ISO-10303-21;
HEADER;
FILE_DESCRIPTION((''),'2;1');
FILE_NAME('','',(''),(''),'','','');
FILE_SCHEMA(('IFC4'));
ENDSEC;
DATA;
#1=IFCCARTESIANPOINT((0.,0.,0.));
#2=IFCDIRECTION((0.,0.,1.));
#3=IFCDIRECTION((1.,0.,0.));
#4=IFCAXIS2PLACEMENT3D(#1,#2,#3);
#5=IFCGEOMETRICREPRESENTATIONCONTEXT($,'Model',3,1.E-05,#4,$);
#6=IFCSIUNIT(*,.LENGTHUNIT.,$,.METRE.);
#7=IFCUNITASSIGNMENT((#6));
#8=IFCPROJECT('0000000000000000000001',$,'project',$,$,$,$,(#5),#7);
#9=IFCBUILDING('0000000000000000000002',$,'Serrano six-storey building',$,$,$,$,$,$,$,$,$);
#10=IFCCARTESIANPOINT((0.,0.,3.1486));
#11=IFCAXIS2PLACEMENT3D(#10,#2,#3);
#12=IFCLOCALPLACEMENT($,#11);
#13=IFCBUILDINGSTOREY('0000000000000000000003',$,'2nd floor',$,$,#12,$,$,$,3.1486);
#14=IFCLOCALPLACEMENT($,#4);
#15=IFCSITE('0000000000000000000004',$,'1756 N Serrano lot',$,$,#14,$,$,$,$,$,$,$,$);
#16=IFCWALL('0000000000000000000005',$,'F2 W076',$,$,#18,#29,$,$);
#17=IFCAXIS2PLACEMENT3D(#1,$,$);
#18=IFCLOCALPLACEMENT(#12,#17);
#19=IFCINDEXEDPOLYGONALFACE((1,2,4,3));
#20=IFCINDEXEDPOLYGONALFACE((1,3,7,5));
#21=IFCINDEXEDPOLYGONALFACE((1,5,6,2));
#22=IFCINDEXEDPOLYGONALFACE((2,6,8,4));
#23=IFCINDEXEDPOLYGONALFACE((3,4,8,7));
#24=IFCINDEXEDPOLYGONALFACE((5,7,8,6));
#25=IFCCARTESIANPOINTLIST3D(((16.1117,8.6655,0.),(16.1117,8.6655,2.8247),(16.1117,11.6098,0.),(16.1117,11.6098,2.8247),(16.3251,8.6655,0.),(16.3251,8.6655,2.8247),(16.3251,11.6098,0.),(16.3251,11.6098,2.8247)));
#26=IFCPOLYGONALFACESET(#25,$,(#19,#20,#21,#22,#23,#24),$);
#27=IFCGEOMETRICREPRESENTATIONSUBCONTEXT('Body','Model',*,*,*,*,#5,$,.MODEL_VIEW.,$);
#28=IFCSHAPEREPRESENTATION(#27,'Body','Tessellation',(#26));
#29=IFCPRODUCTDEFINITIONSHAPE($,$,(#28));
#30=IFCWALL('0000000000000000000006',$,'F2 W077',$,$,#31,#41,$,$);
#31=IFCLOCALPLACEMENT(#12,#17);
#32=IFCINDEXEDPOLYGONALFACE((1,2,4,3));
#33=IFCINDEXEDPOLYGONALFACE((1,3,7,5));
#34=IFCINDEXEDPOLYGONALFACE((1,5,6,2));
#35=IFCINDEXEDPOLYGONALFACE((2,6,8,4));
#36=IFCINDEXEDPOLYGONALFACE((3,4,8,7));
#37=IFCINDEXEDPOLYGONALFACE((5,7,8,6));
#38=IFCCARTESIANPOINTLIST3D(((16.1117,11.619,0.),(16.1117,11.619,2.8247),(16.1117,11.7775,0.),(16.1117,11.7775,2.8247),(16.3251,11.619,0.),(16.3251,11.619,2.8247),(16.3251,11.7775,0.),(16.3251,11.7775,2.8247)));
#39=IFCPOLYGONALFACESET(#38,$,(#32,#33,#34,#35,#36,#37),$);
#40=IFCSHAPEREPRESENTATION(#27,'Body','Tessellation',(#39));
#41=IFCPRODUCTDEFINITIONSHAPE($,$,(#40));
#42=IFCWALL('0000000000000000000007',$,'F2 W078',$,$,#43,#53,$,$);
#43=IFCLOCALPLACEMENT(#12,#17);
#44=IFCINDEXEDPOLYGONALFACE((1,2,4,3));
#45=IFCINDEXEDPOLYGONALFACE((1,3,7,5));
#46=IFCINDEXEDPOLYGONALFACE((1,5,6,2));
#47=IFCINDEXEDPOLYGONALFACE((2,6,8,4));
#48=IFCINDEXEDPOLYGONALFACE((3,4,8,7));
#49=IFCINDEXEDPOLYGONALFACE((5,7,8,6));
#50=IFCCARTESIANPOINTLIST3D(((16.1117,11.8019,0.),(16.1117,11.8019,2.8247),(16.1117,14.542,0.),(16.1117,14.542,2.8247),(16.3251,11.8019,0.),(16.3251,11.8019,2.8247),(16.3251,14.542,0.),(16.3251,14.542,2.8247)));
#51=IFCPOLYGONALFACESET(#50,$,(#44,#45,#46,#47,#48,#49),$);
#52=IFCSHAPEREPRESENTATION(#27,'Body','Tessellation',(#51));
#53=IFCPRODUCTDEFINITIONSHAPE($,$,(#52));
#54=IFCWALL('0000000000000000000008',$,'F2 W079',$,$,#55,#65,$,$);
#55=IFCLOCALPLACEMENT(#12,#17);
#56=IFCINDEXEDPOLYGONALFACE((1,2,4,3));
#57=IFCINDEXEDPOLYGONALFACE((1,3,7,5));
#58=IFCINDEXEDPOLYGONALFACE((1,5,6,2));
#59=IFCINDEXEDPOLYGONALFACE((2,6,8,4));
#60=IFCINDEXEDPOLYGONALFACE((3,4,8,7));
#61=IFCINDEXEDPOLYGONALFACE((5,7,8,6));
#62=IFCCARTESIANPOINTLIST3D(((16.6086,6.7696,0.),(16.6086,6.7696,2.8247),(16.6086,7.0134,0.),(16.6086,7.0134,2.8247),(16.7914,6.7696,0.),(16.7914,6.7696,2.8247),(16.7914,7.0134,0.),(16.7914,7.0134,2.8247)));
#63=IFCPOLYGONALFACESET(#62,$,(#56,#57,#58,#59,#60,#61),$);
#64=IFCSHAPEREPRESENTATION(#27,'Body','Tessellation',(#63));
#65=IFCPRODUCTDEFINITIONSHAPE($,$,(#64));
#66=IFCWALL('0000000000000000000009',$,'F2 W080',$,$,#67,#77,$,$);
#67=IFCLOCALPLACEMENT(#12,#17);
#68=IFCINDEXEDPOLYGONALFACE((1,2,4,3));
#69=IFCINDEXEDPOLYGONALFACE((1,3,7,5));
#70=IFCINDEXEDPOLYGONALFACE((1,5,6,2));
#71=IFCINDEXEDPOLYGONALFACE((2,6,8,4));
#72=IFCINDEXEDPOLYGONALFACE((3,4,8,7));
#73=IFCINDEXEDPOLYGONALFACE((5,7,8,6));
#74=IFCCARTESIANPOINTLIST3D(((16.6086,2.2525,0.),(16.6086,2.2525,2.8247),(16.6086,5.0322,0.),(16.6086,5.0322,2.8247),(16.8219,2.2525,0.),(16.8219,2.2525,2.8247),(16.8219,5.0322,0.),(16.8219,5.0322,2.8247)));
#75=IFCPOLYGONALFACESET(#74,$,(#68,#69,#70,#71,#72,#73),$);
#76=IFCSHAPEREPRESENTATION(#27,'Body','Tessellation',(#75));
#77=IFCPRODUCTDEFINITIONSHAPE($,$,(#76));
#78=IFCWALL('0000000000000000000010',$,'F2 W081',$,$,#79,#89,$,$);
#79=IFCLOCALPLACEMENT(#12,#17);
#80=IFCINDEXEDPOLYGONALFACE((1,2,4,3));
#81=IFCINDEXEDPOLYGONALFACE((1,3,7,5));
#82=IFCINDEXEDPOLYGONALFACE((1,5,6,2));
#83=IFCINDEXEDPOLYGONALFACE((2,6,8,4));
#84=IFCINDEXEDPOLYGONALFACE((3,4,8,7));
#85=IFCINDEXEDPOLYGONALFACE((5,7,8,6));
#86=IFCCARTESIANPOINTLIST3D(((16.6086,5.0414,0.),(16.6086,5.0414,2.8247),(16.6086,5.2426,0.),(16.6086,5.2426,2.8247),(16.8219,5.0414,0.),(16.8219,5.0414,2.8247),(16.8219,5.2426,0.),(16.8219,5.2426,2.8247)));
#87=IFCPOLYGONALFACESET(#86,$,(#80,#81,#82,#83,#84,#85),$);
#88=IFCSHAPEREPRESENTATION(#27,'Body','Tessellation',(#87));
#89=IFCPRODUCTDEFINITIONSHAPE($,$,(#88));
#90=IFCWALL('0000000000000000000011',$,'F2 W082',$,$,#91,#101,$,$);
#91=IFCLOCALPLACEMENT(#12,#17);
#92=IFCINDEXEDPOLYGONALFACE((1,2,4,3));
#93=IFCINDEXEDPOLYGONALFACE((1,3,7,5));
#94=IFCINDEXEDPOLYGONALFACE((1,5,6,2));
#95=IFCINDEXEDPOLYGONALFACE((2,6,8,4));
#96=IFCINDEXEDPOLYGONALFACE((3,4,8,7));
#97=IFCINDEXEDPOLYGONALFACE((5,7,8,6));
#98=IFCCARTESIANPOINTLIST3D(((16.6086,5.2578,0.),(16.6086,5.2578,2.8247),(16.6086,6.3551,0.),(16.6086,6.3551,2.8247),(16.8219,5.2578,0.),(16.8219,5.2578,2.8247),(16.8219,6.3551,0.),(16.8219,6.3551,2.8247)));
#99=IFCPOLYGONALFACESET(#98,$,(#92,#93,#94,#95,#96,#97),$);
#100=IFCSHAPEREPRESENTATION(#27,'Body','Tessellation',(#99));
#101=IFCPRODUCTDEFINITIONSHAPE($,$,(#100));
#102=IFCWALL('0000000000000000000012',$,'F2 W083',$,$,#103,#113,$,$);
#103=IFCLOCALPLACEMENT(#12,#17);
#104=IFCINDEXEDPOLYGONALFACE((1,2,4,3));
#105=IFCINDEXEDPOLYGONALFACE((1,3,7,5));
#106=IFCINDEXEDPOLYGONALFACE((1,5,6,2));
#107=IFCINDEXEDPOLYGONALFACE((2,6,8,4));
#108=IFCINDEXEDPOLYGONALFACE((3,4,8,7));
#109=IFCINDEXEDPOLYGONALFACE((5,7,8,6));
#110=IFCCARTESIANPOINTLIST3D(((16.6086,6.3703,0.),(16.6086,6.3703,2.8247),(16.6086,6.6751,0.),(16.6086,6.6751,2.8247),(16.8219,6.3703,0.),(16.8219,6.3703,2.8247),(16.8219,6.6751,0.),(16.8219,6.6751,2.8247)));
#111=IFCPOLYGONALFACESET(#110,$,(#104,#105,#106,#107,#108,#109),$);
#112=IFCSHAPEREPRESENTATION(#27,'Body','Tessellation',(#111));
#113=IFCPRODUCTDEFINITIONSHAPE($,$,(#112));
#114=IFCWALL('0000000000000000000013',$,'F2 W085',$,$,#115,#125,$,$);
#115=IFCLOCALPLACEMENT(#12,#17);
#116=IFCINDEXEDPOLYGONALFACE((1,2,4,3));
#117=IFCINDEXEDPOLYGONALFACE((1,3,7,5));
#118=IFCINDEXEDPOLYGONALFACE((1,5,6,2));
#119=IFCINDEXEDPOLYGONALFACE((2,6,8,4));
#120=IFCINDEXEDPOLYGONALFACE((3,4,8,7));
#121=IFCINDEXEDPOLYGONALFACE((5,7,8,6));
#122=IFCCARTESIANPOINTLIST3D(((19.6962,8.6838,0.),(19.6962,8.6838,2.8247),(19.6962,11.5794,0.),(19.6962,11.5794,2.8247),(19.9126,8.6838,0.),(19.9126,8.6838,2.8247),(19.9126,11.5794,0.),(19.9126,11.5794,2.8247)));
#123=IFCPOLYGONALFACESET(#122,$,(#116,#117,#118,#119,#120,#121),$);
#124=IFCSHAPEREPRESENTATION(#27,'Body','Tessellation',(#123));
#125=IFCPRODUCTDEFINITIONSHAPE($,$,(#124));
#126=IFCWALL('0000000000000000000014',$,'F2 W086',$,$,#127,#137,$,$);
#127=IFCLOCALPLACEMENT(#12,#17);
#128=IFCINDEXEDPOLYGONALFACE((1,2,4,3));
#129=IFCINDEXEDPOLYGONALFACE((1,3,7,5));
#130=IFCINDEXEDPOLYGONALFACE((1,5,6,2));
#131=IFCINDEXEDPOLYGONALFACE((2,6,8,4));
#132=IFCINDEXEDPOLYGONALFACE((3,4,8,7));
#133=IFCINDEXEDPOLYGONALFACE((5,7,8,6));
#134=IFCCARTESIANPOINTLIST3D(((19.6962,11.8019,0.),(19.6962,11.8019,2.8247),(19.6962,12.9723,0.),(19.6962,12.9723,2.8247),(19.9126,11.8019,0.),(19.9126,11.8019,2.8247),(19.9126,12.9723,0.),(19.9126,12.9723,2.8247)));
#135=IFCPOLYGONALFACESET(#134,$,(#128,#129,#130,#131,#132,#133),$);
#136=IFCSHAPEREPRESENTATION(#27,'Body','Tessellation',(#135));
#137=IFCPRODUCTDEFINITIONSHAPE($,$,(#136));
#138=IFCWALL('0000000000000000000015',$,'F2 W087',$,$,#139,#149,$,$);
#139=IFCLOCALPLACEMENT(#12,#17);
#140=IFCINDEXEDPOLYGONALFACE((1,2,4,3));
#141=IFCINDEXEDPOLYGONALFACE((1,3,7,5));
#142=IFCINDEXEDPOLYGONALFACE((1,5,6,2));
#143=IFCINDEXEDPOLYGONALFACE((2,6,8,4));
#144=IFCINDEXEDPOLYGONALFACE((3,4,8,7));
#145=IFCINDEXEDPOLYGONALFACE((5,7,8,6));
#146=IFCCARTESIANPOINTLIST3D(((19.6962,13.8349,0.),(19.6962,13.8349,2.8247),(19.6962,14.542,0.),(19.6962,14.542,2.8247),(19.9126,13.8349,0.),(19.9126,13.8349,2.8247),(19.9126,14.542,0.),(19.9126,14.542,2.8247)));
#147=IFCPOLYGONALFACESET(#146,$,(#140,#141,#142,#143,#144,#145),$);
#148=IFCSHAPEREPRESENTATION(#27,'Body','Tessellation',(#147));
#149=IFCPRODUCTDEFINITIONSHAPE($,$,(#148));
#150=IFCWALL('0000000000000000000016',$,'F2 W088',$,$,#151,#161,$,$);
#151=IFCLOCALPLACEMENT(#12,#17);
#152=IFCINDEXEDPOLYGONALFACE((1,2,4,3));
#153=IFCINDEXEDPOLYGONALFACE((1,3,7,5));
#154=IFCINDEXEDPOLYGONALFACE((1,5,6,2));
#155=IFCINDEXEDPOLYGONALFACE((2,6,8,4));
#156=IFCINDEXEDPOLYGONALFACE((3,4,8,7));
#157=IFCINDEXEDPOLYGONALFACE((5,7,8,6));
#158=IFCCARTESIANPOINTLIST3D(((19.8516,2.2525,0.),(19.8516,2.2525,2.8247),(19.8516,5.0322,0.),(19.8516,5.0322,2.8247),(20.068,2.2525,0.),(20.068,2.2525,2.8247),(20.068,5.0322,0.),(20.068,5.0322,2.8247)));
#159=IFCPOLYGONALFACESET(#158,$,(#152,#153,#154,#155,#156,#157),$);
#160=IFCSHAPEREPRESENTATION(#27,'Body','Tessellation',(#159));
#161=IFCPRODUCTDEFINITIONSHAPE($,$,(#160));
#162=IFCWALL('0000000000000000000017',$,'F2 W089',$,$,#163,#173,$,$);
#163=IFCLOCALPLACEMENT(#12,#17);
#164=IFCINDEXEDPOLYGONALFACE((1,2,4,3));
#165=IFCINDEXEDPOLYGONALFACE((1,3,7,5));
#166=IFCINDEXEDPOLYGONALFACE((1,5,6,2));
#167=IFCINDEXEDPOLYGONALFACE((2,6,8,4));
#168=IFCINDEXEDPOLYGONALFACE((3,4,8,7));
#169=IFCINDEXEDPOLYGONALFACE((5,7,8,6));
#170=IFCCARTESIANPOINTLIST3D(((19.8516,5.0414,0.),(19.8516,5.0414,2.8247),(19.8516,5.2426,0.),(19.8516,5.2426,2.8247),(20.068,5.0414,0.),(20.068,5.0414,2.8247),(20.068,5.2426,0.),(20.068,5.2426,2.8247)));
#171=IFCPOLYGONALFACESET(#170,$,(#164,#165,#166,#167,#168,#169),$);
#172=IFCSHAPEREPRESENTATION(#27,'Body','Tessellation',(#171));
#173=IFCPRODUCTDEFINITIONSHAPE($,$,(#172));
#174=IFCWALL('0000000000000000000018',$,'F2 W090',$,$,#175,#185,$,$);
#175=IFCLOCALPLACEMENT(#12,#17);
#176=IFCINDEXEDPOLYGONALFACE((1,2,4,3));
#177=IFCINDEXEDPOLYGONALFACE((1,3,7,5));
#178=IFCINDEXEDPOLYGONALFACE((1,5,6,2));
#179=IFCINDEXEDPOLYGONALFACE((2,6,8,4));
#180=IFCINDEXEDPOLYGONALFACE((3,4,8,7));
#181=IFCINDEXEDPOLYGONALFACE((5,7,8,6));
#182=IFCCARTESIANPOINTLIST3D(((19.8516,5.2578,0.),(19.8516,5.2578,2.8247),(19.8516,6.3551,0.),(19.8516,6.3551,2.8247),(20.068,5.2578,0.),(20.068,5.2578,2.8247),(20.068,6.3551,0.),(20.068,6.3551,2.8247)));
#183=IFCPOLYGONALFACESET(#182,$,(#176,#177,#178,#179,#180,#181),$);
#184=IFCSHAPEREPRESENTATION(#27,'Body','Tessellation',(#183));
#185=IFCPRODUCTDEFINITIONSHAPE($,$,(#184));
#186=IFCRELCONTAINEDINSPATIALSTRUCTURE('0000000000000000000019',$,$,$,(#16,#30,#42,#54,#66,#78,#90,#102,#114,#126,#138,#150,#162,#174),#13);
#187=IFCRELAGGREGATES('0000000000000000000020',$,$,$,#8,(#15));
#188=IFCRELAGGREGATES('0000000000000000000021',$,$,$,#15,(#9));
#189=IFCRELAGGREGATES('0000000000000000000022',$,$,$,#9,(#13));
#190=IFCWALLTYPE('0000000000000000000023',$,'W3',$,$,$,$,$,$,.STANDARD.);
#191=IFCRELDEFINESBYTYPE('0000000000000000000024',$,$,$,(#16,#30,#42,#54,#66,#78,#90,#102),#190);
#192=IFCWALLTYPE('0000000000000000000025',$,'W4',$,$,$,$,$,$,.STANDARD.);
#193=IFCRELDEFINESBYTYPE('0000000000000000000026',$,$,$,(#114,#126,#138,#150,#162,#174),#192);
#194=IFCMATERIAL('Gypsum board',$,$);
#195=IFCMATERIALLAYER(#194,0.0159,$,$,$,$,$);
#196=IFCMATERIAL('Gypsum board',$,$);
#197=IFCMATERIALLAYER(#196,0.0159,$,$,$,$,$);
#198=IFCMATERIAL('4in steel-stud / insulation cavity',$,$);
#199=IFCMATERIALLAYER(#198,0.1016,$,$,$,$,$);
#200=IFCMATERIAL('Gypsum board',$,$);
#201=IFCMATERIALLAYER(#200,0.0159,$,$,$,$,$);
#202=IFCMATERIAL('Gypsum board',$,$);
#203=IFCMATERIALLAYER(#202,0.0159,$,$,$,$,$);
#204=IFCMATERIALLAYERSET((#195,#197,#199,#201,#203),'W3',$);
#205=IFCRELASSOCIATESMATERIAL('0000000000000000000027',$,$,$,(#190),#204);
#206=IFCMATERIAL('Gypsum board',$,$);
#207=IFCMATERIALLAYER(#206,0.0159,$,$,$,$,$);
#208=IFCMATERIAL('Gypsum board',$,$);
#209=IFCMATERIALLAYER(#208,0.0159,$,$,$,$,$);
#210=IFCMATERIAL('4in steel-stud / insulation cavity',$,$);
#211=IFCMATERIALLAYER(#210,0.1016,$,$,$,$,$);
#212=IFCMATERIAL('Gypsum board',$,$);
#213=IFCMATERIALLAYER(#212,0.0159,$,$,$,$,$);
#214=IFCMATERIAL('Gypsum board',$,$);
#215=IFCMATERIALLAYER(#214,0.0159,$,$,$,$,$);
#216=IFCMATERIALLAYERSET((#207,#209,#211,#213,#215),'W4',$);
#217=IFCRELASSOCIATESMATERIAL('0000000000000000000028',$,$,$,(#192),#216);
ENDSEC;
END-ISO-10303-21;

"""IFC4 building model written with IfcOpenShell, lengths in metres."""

from ifc_helpers import new_model, si_unit, frame, origin_with_axes, place, context, subcontext, project, spatial, polyline, outline, extrude, material, layer, layer_set, type_object, element, save


model = new_model("IFC4")

# Units and contexts
model_context = context("Model", 3, precision=1e-05, world=origin_with_axes())
body_context = subcontext(model_context, "Body", "Model", "MODEL_VIEW")
ifc_project = project(units=[si_unit("LENGTHUNIT", "METRE")], contexts=[model_context])

# Site, building, storey
site_placement = place(None, origin_with_axes())
site = spatial("IfcSite", under=ifc_project, at=site_placement, Name="1756 N Serrano lot")
building = spatial("IfcBuilding", under=site, Name="Serrano six-storey building")
storey_placement = place(None, frame((0.0, 0.0, 3.1486), z_axis=(0.0, 0.0, 1.0), x_axis=(1.0, 0.0, 0.0)))
storey = spatial("IfcBuildingStorey", under=building, at=storey_placement, Name="2nd floor", Elevation=3.1486)

# Walls
ifc_material_1 = material(Name="Gypsum board")
ifc_layer_1 = layer(ifc_material_1, 0.0159)
ifc_material_2 = material(Name="Gypsum board")
ifc_layer_2 = layer(ifc_material_2, 0.0159)
ifc_material_3 = material(Name="4in steel-stud / insulation cavity")
ifc_layer_3 = layer(ifc_material_3, 0.1016)
ifc_material_4 = material(Name="Gypsum board")
ifc_layer_4 = layer(ifc_material_4, 0.0159)
ifc_material_5 = material(Name="Gypsum board")
ifc_layer_5 = layer(ifc_material_5, 0.0159)
ifc_layer_set_1 = layer_set([ifc_layer_1, ifc_layer_2, ifc_layer_3, ifc_layer_4, ifc_layer_5], Name="W3")
wall_type_1 = type_object("IfcWallType", Name="W3", PredefinedType="STANDARD", material=ifc_layer_set_1)
wall_1_placement = place(storey_placement, frame((0.0, 0.0, -3.1486), z_axis=(0.0, 0.0, 1.0), x_axis=(1.0, 0.0, 0.0)))
element("IfcWall", 1, at=wall_1_placement, inside=storey, type_object=wall_type_1, Name="F2 W076", context=body_context, shape_type="SweptSolid", body=[
    extrude(outline(polyline([(16.1117, 11.6098), (16.3251, 11.6098), (16.3251, 8.6655), (16.1117, 8.6655), (16.1117, 11.6098)])), frame((0.0, 0.0, 3.1486)), (0.0, 0.0, 1.0), 2.8247),
])
wall_2_placement = place(storey_placement, frame((0.0, 0.0, -3.1486), z_axis=(0.0, 0.0, 1.0), x_axis=(1.0, 0.0, 0.0)))
element("IfcWall", 2, at=wall_2_placement, inside=storey, type_object=wall_type_1, Name="F2 W077", context=body_context, shape_type="SweptSolid", body=[
    extrude(outline(polyline([(16.1117, 11.7775), (16.3251, 11.7775), (16.3251, 11.619), (16.1117, 11.619), (16.1117, 11.7775)])), frame((0.0, 0.0, 3.1486)), (0.0, 0.0, 1.0), 2.8247),
])
wall_3_placement = place(storey_placement, frame((0.0, 0.0, -3.1486), z_axis=(0.0, 0.0, 1.0), x_axis=(1.0, 0.0, 0.0)))
element("IfcWall", 3, at=wall_3_placement, inside=storey, type_object=wall_type_1, Name="F2 W078", context=body_context, shape_type="SweptSolid", body=[
    extrude(outline(polyline([(16.1117, 14.542), (16.3251, 14.542), (16.3251, 11.8019), (16.1117, 11.8019), (16.1117, 14.542)])), frame((0.0, 0.0, 3.1486)), (0.0, 0.0, 1.0), 2.8247),
])
wall_4_placement = place(storey_placement, frame((0.0, 0.0, -3.1486), z_axis=(0.0, 0.0, 1.0), x_axis=(1.0, 0.0, 0.0)))
element("IfcWall", 4, at=wall_4_placement, inside=storey, type_object=wall_type_1, Name="F2 W079", context=body_context, shape_type="SweptSolid", body=[
    extrude(outline(polyline([(16.6086, 7.0134), (16.7914, 7.0134), (16.7914, 6.7696), (16.6086, 6.7696), (16.6086, 7.0134)])), frame((0.0, 0.0, 3.1486)), (0.0, 0.0, 1.0), 2.8247),
])
wall_5_placement = place(storey_placement, frame((0.0, 0.0, -3.1486), z_axis=(0.0, 0.0, 1.0), x_axis=(1.0, 0.0, 0.0)))
element("IfcWall", 5, at=wall_5_placement, inside=storey, type_object=wall_type_1, Name="F2 W080", context=body_context, shape_type="SweptSolid", body=[
    extrude(outline(polyline([(16.6086, 5.0322), (16.8219, 5.0322), (16.8219, 2.2525), (16.6086, 2.2525), (16.6086, 5.0322)])), frame((0.0, 0.0, 3.1486)), (0.0, 0.0, 1.0), 2.8247),
])
wall_6_placement = place(storey_placement, frame((0.0, 0.0, -3.1486), z_axis=(0.0, 0.0, 1.0), x_axis=(1.0, 0.0, 0.0)))
element("IfcWall", 6, at=wall_6_placement, inside=storey, type_object=wall_type_1, Name="F2 W081", context=body_context, shape_type="SweptSolid", body=[
    extrude(outline(polyline([(16.6086, 5.2426), (16.8219, 5.2426), (16.8219, 5.0414), (16.6086, 5.0414), (16.6086, 5.2426)])), frame((0.0, 0.0, 3.1486)), (0.0, 0.0, 1.0), 2.8247),
])
wall_7_placement = place(storey_placement, frame((0.0, 0.0, -3.1486), z_axis=(0.0, 0.0, 1.0), x_axis=(1.0, 0.0, 0.0)))
element("IfcWall", 7, at=wall_7_placement, inside=storey, type_object=wall_type_1, Name="F2 W082", context=body_context, shape_type="SweptSolid", body=[
    extrude(outline(polyline([(16.6086, 6.3551), (16.8219, 6.3551), (16.8219, 5.2578), (16.6086, 5.2578), (16.6086, 6.3551)])), frame((0.0, 0.0, 3.1486)), (0.0, 0.0, 1.0), 2.8247),
])
wall_8_placement = place(storey_placement, frame((0.0, 0.0, -3.1486), z_axis=(0.0, 0.0, 1.0), x_axis=(1.0, 0.0, 0.0)))
element("IfcWall", 8, at=wall_8_placement, inside=storey, type_object=wall_type_1, Name="F2 W083", context=body_context, shape_type="SweptSolid", body=[
    extrude(outline(polyline([(16.6086, 6.6751), (16.8219, 6.6751), (16.8219, 6.3703), (16.6086, 6.3703), (16.6086, 6.6751)])), frame((0.0, 0.0, 3.1486)), (0.0, 0.0, 1.0), 2.8247),
])
ifc_material_6 = material(Name="Gypsum board")
ifc_layer_6 = layer(ifc_material_6, 0.0159)
ifc_material_7 = material(Name="Gypsum board")
ifc_layer_7 = layer(ifc_material_7, 0.0159)
ifc_material_8 = material(Name="4in steel-stud / insulation cavity")
ifc_layer_8 = layer(ifc_material_8, 0.1016)
ifc_material_9 = material(Name="Gypsum board")
ifc_layer_9 = layer(ifc_material_9, 0.0159)
ifc_material_10 = material(Name="Gypsum board")
ifc_layer_10 = layer(ifc_material_10, 0.0159)
ifc_layer_set_2 = layer_set([ifc_layer_6, ifc_layer_7, ifc_layer_8, ifc_layer_9, ifc_layer_10], Name="W4")
wall_type_2 = type_object("IfcWallType", Name="W4", PredefinedType="STANDARD", material=ifc_layer_set_2)
wall_9_placement = place(storey_placement, frame((0.0, 0.0, -3.1486), z_axis=(0.0, 0.0, 1.0), x_axis=(1.0, 0.0, 0.0)))
element("IfcWall", 9, at=wall_9_placement, inside=storey, type_object=wall_type_2, Name="F2 W085", context=body_context, shape_type="SweptSolid", body=[
    extrude(outline(polyline([(19.6962, 11.5794), (19.9126, 11.5794), (19.9126, 8.6838), (19.6962, 8.6838), (19.6962, 11.5794)])), frame((0.0, 0.0, 3.1486)), (0.0, 0.0, 1.0), 2.8247),
])
wall_10_placement = place(storey_placement, frame((0.0, 0.0, -3.1486), z_axis=(0.0, 0.0, 1.0), x_axis=(1.0, 0.0, 0.0)))
element("IfcWall", 10, at=wall_10_placement, inside=storey, type_object=wall_type_2, Name="F2 W086", context=body_context, shape_type="SweptSolid", body=[
    extrude(outline(polyline([(19.6962, 12.9723), (19.9126, 12.9723), (19.9126, 11.8019), (19.6962, 11.8019), (19.6962, 12.9723)])), frame((0.0, 0.0, 3.1486)), (0.0, 0.0, 1.0), 2.8247),
])
wall_11_placement = place(storey_placement, frame((0.0, 0.0, -3.1486), z_axis=(0.0, 0.0, 1.0), x_axis=(1.0, 0.0, 0.0)))
element("IfcWall", 11, at=wall_11_placement, inside=storey, type_object=wall_type_2, Name="F2 W087", context=body_context, shape_type="SweptSolid", body=[
    extrude(outline(polyline([(19.6962, 14.542), (19.9126, 14.542), (19.9126, 13.8349), (19.6962, 13.8349), (19.6962, 14.542)])), frame((0.0, 0.0, 3.1486)), (0.0, 0.0, 1.0), 2.8247),
])
wall_12_placement = place(storey_placement, frame((0.0, 0.0, -3.1486), z_axis=(0.0, 0.0, 1.0), x_axis=(1.0, 0.0, 0.0)))
element("IfcWall", 12, at=wall_12_placement, inside=storey, type_object=wall_type_2, Name="F2 W088", context=body_context, shape_type="SweptSolid", body=[
    extrude(outline(polyline([(19.8516, 5.0322), (20.068, 5.0322), (20.068, 2.2525), (19.8516, 2.2525), (19.8516, 5.0322)])), frame((0.0, 0.0, 3.1486)), (0.0, 0.0, 1.0), 2.8247),
])
wall_13_placement = place(storey_placement, frame((0.0, 0.0, -3.1486), z_axis=(0.0, 0.0, 1.0), x_axis=(1.0, 0.0, 0.0)))
element("IfcWall", 13, at=wall_13_placement, inside=storey, type_object=wall_type_2, Name="F2 W089", context=body_context, shape_type="SweptSolid", body=[
    extrude(outline(polyline([(19.8516, 5.2426), (20.068, 5.2426), (20.068, 5.0414), (19.8516, 5.0414), (19.8516, 5.2426)])), frame((0.0, 0.0, 3.1486)), (0.0, 0.0, 1.0), 2.8247),
])
wall_14_placement = place(storey_placement, frame((0.0, 0.0, -3.1486), z_axis=(0.0, 0.0, 1.0), x_axis=(1.0, 0.0, 0.0)))
element("IfcWall", 14, at=wall_14_placement, inside=storey, type_object=wall_type_2, Name="F2 W090", context=body_context, shape_type="SweptSolid", body=[
    extrude(outline(polyline([(19.8516, 6.3551), (20.068, 6.3551), (20.068, 5.2578), (19.8516, 5.2578), (19.8516, 6.3551)])), frame((0.0, 0.0, 3.1486)), (0.0, 0.0, 1.0), 2.8247),
])

save(model, "model.ifc")
